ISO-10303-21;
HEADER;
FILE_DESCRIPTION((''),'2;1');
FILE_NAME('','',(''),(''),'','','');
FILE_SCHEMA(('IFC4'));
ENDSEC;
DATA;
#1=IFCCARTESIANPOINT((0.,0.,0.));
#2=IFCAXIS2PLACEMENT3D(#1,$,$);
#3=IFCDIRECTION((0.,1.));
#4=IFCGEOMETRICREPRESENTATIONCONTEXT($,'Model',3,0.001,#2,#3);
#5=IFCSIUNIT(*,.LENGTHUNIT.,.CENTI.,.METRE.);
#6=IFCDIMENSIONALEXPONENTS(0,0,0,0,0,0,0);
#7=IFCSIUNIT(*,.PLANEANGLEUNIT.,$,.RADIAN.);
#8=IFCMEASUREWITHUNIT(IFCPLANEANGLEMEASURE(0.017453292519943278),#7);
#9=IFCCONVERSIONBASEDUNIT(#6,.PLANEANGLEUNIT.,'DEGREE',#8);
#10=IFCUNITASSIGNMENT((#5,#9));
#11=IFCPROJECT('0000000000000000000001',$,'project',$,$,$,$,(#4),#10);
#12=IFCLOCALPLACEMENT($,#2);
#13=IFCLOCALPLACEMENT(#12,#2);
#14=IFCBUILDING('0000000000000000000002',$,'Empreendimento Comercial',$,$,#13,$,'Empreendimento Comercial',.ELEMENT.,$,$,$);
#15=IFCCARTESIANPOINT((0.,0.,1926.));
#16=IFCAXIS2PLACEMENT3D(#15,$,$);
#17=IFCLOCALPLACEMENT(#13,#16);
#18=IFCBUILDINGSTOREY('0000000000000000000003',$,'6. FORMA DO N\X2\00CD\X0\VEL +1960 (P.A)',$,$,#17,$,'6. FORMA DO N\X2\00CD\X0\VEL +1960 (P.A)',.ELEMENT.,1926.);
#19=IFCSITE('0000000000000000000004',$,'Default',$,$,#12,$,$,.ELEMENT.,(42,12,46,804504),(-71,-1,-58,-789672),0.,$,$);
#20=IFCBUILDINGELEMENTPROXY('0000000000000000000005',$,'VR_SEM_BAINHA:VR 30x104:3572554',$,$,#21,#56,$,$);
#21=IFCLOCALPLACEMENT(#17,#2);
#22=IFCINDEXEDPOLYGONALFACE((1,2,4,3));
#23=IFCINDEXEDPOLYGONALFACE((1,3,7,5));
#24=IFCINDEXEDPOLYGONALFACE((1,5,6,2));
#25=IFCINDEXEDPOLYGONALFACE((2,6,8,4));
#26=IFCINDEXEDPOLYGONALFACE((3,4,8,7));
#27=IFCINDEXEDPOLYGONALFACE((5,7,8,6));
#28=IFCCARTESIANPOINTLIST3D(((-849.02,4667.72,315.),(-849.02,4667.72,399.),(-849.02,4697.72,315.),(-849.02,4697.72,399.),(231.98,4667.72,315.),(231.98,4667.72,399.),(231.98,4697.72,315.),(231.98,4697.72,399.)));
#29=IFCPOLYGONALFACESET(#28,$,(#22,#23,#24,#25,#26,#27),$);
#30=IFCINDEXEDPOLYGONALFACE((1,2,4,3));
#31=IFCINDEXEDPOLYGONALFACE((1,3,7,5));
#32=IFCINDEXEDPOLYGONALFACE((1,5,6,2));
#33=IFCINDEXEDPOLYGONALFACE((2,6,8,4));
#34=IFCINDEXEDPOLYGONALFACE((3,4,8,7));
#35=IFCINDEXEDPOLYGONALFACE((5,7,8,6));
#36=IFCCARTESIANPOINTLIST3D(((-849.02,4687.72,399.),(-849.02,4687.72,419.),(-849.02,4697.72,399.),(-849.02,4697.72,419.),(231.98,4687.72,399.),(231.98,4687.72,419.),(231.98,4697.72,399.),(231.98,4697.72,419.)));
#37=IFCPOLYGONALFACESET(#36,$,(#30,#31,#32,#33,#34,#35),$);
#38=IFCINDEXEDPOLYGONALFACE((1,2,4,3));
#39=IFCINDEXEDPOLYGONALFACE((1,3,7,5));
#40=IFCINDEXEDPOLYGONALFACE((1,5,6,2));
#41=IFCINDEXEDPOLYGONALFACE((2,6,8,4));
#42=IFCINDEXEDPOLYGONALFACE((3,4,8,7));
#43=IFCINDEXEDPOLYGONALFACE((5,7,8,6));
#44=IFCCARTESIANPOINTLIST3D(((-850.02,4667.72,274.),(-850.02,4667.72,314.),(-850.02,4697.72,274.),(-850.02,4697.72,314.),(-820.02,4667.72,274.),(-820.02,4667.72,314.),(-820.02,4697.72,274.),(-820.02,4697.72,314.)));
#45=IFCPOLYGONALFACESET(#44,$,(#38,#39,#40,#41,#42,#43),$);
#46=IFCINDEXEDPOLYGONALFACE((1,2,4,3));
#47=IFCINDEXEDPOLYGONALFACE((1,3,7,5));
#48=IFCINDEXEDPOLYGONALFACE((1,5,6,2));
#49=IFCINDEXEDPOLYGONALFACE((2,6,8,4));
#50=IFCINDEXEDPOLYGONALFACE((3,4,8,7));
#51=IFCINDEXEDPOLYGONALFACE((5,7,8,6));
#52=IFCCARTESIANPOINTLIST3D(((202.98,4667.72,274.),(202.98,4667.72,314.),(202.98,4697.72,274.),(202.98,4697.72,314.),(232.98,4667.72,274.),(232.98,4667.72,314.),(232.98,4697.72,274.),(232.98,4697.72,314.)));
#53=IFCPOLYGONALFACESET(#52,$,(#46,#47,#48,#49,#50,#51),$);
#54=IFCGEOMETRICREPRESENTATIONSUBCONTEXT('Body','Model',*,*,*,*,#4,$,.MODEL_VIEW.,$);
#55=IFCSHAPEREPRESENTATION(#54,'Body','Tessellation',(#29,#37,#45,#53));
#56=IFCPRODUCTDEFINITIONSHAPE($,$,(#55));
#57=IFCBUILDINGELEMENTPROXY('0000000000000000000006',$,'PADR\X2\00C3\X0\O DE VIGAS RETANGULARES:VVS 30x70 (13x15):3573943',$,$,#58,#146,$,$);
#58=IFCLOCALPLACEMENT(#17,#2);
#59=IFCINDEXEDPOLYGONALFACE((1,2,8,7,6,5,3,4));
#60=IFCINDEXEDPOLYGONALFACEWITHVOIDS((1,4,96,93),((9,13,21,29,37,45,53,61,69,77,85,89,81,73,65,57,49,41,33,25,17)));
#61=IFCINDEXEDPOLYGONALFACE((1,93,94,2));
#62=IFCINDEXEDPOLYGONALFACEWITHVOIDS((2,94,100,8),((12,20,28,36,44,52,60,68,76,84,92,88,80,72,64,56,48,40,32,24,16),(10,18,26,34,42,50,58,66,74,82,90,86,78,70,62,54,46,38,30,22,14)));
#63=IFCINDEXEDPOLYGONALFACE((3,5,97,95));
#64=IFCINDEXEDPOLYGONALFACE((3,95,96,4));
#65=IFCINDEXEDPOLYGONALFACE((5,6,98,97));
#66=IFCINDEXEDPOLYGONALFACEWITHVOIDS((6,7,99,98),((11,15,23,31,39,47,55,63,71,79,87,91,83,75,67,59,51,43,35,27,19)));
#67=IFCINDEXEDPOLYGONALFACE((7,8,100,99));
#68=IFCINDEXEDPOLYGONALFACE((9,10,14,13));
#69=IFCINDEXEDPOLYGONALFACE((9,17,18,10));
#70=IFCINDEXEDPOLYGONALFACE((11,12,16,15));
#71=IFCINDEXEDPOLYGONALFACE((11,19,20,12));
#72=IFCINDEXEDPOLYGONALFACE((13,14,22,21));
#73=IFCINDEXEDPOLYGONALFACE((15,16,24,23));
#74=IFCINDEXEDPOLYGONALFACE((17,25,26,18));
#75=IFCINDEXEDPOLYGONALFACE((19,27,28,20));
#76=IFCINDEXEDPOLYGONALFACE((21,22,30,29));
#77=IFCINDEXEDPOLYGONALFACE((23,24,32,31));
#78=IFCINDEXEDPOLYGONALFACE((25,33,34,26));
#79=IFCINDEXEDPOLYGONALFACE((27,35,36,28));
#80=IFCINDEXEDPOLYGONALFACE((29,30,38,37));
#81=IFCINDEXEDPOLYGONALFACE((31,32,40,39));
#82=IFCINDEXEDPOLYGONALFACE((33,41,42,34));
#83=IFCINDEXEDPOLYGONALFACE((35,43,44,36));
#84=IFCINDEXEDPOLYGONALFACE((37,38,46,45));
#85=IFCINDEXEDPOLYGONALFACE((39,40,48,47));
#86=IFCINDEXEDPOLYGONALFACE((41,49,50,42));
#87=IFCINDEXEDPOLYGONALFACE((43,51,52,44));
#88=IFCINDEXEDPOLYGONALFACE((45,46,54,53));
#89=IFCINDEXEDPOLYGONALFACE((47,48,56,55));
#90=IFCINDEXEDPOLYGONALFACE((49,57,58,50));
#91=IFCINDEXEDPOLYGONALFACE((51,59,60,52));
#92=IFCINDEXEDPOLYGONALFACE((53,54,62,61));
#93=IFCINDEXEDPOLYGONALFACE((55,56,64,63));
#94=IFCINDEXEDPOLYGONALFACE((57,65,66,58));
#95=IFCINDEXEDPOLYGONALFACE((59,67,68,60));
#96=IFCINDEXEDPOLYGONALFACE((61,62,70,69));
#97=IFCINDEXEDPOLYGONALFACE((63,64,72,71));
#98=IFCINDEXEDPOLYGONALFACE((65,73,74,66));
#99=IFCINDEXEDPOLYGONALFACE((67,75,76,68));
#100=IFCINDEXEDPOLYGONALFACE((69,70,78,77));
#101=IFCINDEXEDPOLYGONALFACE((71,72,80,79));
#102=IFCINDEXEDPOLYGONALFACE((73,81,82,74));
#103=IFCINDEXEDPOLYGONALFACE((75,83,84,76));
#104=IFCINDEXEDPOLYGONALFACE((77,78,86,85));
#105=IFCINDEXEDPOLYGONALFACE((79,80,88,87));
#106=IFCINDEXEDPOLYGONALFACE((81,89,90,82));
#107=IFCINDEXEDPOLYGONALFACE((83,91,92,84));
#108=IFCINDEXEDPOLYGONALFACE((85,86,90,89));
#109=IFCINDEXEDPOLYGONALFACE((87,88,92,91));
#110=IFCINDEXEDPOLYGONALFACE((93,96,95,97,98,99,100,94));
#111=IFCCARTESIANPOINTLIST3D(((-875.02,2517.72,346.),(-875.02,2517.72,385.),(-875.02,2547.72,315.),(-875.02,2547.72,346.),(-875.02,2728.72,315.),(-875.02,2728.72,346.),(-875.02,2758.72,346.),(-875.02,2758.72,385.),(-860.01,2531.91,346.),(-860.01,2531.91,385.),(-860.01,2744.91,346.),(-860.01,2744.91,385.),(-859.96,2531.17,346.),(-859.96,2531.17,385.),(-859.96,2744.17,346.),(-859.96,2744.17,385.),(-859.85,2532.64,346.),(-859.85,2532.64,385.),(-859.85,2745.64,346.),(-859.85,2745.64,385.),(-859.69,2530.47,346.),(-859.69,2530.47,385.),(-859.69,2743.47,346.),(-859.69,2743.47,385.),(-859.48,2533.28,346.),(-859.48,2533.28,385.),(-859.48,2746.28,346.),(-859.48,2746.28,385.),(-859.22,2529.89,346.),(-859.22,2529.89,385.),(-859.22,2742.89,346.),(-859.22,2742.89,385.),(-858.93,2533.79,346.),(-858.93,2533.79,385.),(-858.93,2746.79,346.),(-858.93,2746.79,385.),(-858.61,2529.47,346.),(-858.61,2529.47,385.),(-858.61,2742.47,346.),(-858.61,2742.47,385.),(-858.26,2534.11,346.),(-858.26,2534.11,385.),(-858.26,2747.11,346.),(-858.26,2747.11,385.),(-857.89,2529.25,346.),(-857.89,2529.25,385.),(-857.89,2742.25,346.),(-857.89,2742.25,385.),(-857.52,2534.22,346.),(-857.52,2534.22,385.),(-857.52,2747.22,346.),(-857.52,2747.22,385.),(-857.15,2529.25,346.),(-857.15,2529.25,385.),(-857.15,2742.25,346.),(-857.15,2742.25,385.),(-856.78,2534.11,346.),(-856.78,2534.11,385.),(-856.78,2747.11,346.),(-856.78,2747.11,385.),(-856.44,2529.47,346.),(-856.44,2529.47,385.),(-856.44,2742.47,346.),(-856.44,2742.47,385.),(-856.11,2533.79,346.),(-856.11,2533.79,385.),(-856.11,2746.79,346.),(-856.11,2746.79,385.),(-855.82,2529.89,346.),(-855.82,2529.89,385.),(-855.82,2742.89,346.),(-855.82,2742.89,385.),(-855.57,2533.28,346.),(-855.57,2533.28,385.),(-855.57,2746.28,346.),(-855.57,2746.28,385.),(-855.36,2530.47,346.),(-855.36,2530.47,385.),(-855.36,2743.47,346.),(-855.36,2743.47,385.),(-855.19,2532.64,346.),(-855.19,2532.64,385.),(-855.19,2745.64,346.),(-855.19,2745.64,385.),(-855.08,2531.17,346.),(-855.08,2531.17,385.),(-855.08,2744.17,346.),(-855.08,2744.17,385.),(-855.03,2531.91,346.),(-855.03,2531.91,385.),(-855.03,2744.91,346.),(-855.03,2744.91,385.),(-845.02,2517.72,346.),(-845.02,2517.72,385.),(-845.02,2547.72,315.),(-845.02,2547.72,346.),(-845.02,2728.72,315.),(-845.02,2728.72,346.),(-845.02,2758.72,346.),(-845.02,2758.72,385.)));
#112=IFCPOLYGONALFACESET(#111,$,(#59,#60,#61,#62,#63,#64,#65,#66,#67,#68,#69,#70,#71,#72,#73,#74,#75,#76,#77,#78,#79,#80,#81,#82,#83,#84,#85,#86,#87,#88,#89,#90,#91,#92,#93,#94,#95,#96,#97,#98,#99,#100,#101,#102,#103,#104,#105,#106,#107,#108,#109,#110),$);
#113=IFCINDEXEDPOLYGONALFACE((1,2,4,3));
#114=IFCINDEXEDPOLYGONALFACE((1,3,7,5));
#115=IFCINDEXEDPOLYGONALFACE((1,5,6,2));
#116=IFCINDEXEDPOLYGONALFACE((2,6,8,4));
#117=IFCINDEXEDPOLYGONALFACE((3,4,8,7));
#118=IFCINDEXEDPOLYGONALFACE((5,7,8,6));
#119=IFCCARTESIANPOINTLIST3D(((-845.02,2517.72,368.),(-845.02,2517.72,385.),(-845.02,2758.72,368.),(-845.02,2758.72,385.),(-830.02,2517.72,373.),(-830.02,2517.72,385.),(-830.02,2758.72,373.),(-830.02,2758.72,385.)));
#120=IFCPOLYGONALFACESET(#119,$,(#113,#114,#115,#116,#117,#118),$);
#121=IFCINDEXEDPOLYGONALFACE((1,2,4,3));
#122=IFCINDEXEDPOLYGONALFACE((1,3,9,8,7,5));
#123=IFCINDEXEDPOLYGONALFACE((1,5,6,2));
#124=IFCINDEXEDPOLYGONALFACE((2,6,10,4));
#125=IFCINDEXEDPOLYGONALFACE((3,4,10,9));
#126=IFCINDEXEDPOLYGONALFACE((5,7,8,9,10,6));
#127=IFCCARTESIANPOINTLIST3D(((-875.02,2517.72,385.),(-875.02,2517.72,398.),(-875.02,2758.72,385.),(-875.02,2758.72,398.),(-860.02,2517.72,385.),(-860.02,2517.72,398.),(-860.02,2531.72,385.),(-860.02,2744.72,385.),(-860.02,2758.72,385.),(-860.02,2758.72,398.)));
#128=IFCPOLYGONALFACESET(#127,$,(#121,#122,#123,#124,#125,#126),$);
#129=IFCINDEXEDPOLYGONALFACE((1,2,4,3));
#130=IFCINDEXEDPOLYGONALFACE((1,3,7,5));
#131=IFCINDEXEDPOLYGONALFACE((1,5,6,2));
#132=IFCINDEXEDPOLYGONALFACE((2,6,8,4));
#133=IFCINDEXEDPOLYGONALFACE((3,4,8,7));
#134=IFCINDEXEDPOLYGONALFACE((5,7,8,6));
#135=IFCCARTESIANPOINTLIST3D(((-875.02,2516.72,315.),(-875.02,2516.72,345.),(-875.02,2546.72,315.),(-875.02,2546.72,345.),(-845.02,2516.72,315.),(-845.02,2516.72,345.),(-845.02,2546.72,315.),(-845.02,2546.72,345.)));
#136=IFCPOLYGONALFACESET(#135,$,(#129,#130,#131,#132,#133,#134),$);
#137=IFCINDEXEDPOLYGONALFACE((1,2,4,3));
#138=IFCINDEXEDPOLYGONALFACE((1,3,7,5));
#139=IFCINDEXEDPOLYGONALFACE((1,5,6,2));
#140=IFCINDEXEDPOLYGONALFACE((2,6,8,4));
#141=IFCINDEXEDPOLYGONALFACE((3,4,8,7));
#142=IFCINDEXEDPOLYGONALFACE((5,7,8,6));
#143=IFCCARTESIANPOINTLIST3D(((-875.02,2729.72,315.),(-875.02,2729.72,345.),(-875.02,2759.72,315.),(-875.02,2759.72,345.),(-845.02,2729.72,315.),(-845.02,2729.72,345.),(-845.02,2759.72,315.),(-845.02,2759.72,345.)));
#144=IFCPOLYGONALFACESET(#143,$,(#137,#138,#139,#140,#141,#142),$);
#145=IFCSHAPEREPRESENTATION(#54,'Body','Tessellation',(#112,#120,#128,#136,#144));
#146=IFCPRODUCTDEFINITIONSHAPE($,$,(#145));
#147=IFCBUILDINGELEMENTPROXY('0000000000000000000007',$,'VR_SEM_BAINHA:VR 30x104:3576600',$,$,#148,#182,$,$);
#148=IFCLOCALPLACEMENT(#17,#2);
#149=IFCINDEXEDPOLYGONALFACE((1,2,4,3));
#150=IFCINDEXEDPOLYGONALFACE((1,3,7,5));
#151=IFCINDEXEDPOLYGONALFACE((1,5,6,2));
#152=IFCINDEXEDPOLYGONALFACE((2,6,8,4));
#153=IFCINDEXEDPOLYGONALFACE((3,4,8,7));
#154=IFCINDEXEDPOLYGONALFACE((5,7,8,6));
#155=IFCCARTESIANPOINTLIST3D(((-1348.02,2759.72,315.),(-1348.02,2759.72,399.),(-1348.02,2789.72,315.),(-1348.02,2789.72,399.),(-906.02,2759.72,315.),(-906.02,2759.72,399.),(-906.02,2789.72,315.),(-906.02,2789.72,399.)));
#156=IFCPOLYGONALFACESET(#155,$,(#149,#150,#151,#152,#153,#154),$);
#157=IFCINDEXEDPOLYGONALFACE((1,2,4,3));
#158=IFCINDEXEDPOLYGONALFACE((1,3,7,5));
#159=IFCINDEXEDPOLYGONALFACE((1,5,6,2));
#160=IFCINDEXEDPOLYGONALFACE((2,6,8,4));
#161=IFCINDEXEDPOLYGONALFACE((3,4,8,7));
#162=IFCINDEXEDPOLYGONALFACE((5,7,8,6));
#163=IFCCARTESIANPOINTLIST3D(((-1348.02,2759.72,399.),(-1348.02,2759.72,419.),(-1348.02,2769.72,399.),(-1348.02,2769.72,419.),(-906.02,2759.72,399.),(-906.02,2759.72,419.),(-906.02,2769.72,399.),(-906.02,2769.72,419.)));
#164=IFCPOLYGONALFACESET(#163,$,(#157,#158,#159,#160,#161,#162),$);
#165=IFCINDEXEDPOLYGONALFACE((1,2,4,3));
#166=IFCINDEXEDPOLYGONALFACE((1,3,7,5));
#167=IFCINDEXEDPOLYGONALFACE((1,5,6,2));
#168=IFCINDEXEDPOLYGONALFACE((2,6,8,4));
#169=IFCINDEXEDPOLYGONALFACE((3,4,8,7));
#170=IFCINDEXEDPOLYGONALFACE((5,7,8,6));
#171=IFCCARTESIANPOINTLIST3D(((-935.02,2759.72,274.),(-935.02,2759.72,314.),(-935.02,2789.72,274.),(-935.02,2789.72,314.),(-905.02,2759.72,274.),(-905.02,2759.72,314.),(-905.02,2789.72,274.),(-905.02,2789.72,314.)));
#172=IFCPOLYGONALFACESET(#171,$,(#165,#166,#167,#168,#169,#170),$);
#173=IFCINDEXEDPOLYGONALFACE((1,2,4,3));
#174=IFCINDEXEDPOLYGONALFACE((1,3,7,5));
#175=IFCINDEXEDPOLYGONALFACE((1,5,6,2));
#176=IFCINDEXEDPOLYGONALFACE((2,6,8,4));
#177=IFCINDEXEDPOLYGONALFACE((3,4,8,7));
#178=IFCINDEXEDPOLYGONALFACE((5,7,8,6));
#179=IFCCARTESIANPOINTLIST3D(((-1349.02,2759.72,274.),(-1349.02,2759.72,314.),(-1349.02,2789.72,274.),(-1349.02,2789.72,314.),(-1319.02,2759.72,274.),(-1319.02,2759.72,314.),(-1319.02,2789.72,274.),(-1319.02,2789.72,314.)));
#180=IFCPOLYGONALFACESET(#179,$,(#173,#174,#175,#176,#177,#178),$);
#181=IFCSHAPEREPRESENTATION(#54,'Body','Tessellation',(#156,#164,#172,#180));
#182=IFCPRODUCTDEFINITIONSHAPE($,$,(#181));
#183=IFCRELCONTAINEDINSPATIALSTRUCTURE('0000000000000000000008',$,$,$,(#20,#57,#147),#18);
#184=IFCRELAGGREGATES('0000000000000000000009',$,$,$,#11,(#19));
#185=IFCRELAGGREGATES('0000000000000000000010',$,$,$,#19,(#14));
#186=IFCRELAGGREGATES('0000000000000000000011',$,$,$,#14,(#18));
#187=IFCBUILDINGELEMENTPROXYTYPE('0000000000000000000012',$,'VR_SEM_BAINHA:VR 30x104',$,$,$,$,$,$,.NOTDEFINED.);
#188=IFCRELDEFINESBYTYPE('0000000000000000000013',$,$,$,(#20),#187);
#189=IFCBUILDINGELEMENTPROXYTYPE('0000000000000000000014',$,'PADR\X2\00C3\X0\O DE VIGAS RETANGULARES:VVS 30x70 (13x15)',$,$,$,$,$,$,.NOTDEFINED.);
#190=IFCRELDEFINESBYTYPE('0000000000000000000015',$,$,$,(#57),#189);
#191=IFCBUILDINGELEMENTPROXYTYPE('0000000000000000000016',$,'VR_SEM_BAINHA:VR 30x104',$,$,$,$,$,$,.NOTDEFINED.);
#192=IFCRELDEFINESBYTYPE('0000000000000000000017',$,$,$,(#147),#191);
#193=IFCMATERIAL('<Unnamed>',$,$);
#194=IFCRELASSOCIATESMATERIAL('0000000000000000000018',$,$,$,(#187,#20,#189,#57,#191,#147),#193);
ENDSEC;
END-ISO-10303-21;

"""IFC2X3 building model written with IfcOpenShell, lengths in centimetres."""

from ifc_helpers import new_model, entity, si_unit, converted_unit, direction, frame, frame_2d, origin, origin_2d_with_axis, place, context, subcontext, project, spatial, polyline, rectangle, circle, outline, extrude, source, transform, mapped, material, type_object, type_shapes, element, save


model = new_model("IFC2X3")

# Units and contexts
model_context = context("Model", 3, precision=0.001, world=origin(), true_north=direction((0.0, 1.0)))
body_context = subcontext(model_context, "Body", "Model", "MODEL_VIEW")
ifc_project = project(units=[si_unit("LENGTHUNIT", "METRE", prefix="CENTI"), converted_unit("PLANEANGLEUNIT", "DEGREE", entity("IfcPlaneAngleMeasure", 0.017453292519943278), si_unit("PLANEANGLEUNIT", "RADIAN"), dimensions=[0, 0, 0, 0, 0, 0, 0])], contexts=[model_context])

# Site, building, storey
site_placement = place(None, origin())
site = spatial("IfcSite", under=ifc_project, at=site_placement, Name="Default", CompositionType="ELEMENT", RefLatitude=(42, 12, 46, 804504), RefLongitude=(-71, -1, -58, -789672), RefElevation=0.0)
building_placement = place(site_placement, origin())
building = spatial("IfcBuilding", under=site, at=building_placement, Name="Empreendimento Comercial", LongName="Empreendimento Comercial", CompositionType="ELEMENT")
storey_placement = place(building_placement, frame((0.0, 0.0, 1926.0)))
storey = spatial("IfcBuildingStorey", under=building, at=storey_placement, Name="6. FORMA DO NÍVEL +1960 (P.A)", LongName="6. FORMA DO NÍVEL +1960 (P.A)", CompositionType="ELEMENT", Elevation=1926.0)

# Building element proxy
ifc_material = material(Name="<Unnamed>")
building_element_proxy_type_1 = type_object("IfcBuildingElementProxyType", Name="VR_SEM_BAINHA:VR 30x104", PredefinedType="NOTDEFINED", material=ifc_material)
shared_shape_1 = source(origin(), body_context, "Body", "SweptSolid", [
    extrude(rectangle(XDim=1081.0, YDim=30.0, at=origin_2d_with_axis()), frame((-308.52, 4682.72, 2241.0), z_axis=(0.0, 0.0, 1.0), x_axis=(-1.0, 0.0, 0.0)), (0.0, 0.0, 1.0), 84.0),
    extrude(rectangle(XDim=1081.0, YDim=10.0, at=frame_2d((0.0, 0.0), x_axis=(1.0, 0.0))), frame((-308.52, 4692.72, 2325.0), z_axis=(0.0, 0.0, 1.0), x_axis=(-1.0, 0.0, 0.0)), (0.0, 0.0, 1.0), 20.0),
    extrude(rectangle(XDim=30.0, YDim=30.0, at=origin_2d_with_axis()), frame((-835.02, 4682.72, 2200.0), z_axis=(0.0, 0.0, 1.0), x_axis=(0.0, 1.0, 0.0)), (0.0, 0.0, 1.0), 40.0),
    extrude(rectangle(XDim=30.0, YDim=30.0, at=origin_2d_with_axis()), frame((217.98, 4682.72, 2200.0), z_axis=(0.0, 0.0, 1.0), x_axis=(0.0, 1.0, 0.0)), (0.0, 0.0, 1.0), 40.0),
])
type_shapes(building_element_proxy_type_1, [shared_shape_1])
proxy_1_placement = place(storey_placement, frame((0.0, 0.0, -1926.0)))
element("IfcBuildingElementProxy", 1, at=proxy_1_placement, inside=storey, type_object=building_element_proxy_type_1, material=ifc_material, Name="VR_SEM_BAINHA:VR 30x104:3572554", context=body_context, shape_type="MappedRepresentation", body=[
    mapped(shared_shape_1, transform((0.0, 0.0, 0.0), scale=1.0)),
])

# Building element proxy, openings
building_element_proxy_type_2 = type_object("IfcBuildingElementProxyType", Name="PADRÃO DE VIGAS RETANGULARES:VVS 30x70 (13x15)", PredefinedType="NOTDEFINED", material=ifc_material)
shared_shape_2 = source(origin(), body_context, "Body", "SweptSolid", [
    extrude(outline(polyline([(-37.0, -120.5), (2.0, -120.5), (2.0, -90.5), (33.0, -90.5), (33.0, 90.5), (2.0, 90.5), (2.0, 120.5), (-37.0, 120.5), (-37.0, -120.5)])), frame((-875.02, 2638.22, 2274.0), z_axis=(1.0, 0.0, 0.0), x_axis=(0.0, 0.0, -1.0)), (0.0, 0.0, 1.0), 30.0),
    extrude(outline(polyline([(-7.25, -7.5), (4.75, -7.5), (9.75, 7.5), (-7.25, 7.5), (-7.25, -7.5)])), frame((-837.52, 2517.72, 2303.75), z_axis=(0.0, 1.0, 0.0), x_axis=(0.0, 0.0, -1.0)), (0.0, 0.0, 1.0), 241.0),
    extrude(rectangle(XDim=241.0, YDim=15.0, at=origin_2d_with_axis()), frame((-867.52, 2638.22, 2311.0), z_axis=(0.0, 0.0, 1.0), x_axis=(0.0, -1.0, 0.0)), (0.0, 0.0, 1.0), 13.0),
    extrude(rectangle(XDim=30.0, YDim=30.0, at=frame_2d((0.0, 0.0), x_axis=(1.0, 0.0))), frame((-860.02, 2531.72, 2241.0), z_axis=(0.0, 0.0, 1.0), x_axis=(-1.0, 0.0, 0.0)), (0.0, 0.0, 1.0), 30.0),
    extrude(rectangle(XDim=30.0, YDim=30.0, at=frame_2d((0.0, 0.0), x_axis=(1.0, 0.0))), frame((-860.02, 2744.72, 2241.0), z_axis=(0.0, 0.0, 1.0), x_axis=(-1.0, 0.0, 0.0)), (0.0, 0.0, 1.0), 30.0),
])
type_shapes(building_element_proxy_type_2, [shared_shape_2])
proxy_2_placement = place(storey_placement, frame((0.0, 0.0, -1926.0)))
proxy_2 = element("IfcBuildingElementProxy", 2, at=proxy_2_placement, inside=storey, type_object=building_element_proxy_type_2, material=ifc_material, Name="PADRÃO DE VIGAS RETANGULARES:VVS 30x70 (13x15):3573943", context=body_context, shape_type="MappedRepresentation", body=[
    mapped(shared_shape_2, transform((0.0, 0.0, 0.0), scale=1.0)),
])
opening_1_placement = place(storey_placement, frame((0.0, 0.0, -1926.0)))
element("IfcOpeningElement", 3, at=opening_1_placement, cuts=proxy_2, ObjectType="Opening", context=body_context, shape_type="SweptSolid", body=[
    extrude(circle(Radius=2.5, at=origin_2d_with_axis()), frame((-857.52, 2744.72, 2272.0), z_axis=(0.0, 0.0, 1.0), x_axis=(0.0, 1.0, 0.0)), (0.0, 0.0, 1.0), 39.0),
])
opening_2_placement = place(storey_placement, frame((0.0, 0.0, -1926.0)))
element("IfcOpeningElement", 4, at=opening_2_placement, cuts=proxy_2, ObjectType="Opening", context=body_context, shape_type="SweptSolid", body=[
    extrude(circle(Radius=2.5, at=origin_2d_with_axis()), frame((-857.52, 2531.72, 2272.0), z_axis=(0.0, 0.0, 1.0), x_axis=(0.0, 1.0, 0.0)), (0.0, 0.0, 1.0), 39.0),
])

# Building element proxy
building_element_proxy_type_3 = type_object("IfcBuildingElementProxyType", Name="VR_SEM_BAINHA:VR 30x104", PredefinedType="NOTDEFINED", material=ifc_material)
shared_shape_3 = source(origin(), body_context, "Body", "SweptSolid", [
    extrude(rectangle(XDim=442.0, YDim=30.0, at=frame_2d((0.0, 0.0), x_axis=(1.0, 0.0))), frame((-1127.02, 2774.72, 2241.0)), (0.0, 0.0, 1.0), 84.0),
    extrude(rectangle(XDim=442.0, YDim=10.0, at=frame_2d((0.0, 0.0), x_axis=(1.0, 0.0))), frame((-1127.02, 2764.72, 2325.0)), (0.0, 0.0, 1.0), 20.0),
    extrude(rectangle(XDim=30.0, YDim=30.0, at=origin_2d_with_axis()), frame((-920.02, 2774.72, 2200.0), z_axis=(0.0, 0.0, 1.0), x_axis=(0.0, -1.0, 0.0)), (0.0, 0.0, 1.0), 40.0),
    extrude(rectangle(XDim=30.0, YDim=30.0, at=frame_2d((0.0, 0.0), x_axis=(1.0, 0.0))), frame((-1334.02, 2774.72, 2200.0), z_axis=(0.0, 0.0, 1.0), x_axis=(0.0, -1.0, 0.0)), (0.0, 0.0, 1.0), 40.0),
])
type_shapes(building_element_proxy_type_3, [shared_shape_3])
proxy_3_placement = place(storey_placement, frame((0.0, 0.0, -1926.0)))
element("IfcBuildingElementProxy", 5, at=proxy_3_placement, inside=storey, type_object=building_element_proxy_type_3, material=ifc_material, Name="VR_SEM_BAINHA:VR 30x104:3576600", context=body_context, shape_type="MappedRepresentation", body=[
    mapped(shared_shape_3, transform((0.0, 0.0, 0.0), scale=1.0)),
])

save(model, "model.ifc")
